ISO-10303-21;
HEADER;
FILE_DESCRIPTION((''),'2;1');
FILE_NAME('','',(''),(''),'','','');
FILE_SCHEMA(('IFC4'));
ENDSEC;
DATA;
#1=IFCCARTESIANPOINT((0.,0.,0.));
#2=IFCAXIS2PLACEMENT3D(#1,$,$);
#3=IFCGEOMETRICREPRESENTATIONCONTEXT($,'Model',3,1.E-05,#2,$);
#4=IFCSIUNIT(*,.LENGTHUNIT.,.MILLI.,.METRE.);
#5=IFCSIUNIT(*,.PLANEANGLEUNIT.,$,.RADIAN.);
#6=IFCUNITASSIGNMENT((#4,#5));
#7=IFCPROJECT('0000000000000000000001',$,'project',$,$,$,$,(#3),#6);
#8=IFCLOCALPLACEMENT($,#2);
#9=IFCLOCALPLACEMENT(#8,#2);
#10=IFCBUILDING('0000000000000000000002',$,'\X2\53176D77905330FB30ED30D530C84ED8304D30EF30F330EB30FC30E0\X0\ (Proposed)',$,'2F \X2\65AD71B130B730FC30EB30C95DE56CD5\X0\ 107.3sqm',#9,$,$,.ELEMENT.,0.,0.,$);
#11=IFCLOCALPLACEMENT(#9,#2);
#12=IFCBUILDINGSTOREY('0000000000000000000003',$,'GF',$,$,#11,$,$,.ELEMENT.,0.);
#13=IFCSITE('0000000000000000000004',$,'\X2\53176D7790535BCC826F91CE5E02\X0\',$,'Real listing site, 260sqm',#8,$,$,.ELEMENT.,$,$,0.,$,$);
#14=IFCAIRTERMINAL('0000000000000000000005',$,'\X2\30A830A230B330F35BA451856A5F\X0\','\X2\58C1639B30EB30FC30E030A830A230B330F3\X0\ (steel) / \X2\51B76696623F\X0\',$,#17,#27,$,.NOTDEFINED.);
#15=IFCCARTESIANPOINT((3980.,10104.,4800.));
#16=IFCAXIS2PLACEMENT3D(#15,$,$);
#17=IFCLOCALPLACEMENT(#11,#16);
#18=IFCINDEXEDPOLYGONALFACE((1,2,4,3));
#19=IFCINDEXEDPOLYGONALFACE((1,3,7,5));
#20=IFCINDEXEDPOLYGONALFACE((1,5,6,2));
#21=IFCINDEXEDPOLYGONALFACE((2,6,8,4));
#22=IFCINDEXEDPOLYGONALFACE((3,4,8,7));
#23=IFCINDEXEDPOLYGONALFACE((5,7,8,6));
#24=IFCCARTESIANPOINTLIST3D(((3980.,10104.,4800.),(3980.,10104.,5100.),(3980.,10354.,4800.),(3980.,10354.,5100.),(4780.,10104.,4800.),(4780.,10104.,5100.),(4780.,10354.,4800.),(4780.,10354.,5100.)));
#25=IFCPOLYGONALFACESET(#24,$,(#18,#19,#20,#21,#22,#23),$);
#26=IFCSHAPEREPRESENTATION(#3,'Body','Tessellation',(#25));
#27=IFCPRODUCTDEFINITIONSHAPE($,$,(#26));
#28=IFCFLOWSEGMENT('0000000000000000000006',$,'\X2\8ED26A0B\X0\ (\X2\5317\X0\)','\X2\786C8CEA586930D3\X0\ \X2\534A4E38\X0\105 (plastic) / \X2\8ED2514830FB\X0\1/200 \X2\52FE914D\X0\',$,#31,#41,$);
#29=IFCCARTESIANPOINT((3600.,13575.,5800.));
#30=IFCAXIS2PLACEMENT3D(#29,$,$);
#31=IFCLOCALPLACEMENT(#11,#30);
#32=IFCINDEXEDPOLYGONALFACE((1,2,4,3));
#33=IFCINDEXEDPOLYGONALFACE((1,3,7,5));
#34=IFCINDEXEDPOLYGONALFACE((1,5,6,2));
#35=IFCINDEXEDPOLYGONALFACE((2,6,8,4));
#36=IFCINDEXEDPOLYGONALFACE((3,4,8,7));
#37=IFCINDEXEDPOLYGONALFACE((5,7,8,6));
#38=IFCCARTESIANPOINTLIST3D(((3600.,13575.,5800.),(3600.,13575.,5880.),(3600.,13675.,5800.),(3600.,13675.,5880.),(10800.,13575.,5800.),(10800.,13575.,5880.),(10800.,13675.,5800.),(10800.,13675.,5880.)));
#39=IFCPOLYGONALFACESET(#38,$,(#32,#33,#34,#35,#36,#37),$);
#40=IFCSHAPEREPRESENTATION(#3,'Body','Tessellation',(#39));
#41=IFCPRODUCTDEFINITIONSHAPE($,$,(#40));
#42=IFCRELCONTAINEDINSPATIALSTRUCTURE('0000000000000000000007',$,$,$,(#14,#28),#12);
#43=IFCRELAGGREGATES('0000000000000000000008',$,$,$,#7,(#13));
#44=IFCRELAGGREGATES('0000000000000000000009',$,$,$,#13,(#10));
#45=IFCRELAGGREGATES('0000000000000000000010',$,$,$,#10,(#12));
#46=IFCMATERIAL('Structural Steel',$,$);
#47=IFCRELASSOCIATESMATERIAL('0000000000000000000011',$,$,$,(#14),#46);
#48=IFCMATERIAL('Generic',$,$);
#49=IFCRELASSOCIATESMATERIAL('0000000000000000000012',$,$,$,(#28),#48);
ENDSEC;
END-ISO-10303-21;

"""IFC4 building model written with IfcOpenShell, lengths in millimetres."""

from ifc_helpers import new_model, si_unit, frame, frame_2d, origin, place, context, project, spatial, rectangle, extrude, material, element, save


model = new_model("IFC4")

# Units and contexts
model_context = context("Model", 3, precision=1e-05, world=origin())
ifc_project = project(units=[si_unit("LENGTHUNIT", "METRE", prefix="MILLI"), si_unit("PLANEANGLEUNIT", "RADIAN")], contexts=[model_context])

# Site, building, storey
site_placement = place(None, origin())
site = spatial("IfcSite", under=ifc_project, at=site_placement, Name="北海道富良野市", ObjectType="Real listing site, 260sqm", CompositionType="ELEMENT", RefElevation=0.0)
building_placement = place(site_placement, origin())
building = spatial("IfcBuilding", under=site, at=building_placement, Name="北海道・ロフト付きワンルーム (Proposed)", ObjectType="2F 断熱シールド工法 107.3sqm", CompositionType="ELEMENT", ElevationOfRefHeight=0.0, ElevationOfTerrain=0.0)
storey_placement = place(building_placement, origin())
storey = spatial("IfcBuildingStorey", under=building, at=storey_placement, Name="GF", CompositionType="ELEMENT", Elevation=0.0)

# Shared definitions
ifc_material_1 = material(Name="Structural Steel")

# Shared definitions
ifc_material_2 = material(Name="Generic")

# Air terminal
air_terminal_placement = place(storey_placement, frame((3980.0, 10104.0, 4800.0)))
element("IfcAirTerminal", 1, at=air_terminal_placement, inside=storey, material=ifc_material_1, Name="エアコン室内機", Description="壁掛ルームエアコン (steel) / 冷暖房", PredefinedType="NOTDEFINED", context=model_context, shape_type="SweptSolid", body=[
    extrude(rectangle(XDim=800.0, YDim=250.0, at=frame_2d((400.0, 125.0))), frame((3980.0, 10104.0, 4800.0)), (0.0, 0.0, 1.0), 300.0),
])

# Flow segment
flow_segment_placement = place(storey_placement, frame((3600.0, 13575.0, 5800.0)))
element("IfcFlowSegment", 2, at=flow_segment_placement, inside=storey, material=ifc_material_2, Name="軒樋 (北)", Description="硬質塩ビ 半丸105 (plastic) / 軒先・1/200 勾配", context=model_context, shape_type="SweptSolid", body=[
    extrude(rectangle(XDim=7200.0, YDim=100.0, at=frame_2d((3600.0, 50.0))), frame((3600.0, 13575.0, 5800.0)), (0.0, 0.0, 1.0), 80.0),
])

save(model, "model.ifc")
